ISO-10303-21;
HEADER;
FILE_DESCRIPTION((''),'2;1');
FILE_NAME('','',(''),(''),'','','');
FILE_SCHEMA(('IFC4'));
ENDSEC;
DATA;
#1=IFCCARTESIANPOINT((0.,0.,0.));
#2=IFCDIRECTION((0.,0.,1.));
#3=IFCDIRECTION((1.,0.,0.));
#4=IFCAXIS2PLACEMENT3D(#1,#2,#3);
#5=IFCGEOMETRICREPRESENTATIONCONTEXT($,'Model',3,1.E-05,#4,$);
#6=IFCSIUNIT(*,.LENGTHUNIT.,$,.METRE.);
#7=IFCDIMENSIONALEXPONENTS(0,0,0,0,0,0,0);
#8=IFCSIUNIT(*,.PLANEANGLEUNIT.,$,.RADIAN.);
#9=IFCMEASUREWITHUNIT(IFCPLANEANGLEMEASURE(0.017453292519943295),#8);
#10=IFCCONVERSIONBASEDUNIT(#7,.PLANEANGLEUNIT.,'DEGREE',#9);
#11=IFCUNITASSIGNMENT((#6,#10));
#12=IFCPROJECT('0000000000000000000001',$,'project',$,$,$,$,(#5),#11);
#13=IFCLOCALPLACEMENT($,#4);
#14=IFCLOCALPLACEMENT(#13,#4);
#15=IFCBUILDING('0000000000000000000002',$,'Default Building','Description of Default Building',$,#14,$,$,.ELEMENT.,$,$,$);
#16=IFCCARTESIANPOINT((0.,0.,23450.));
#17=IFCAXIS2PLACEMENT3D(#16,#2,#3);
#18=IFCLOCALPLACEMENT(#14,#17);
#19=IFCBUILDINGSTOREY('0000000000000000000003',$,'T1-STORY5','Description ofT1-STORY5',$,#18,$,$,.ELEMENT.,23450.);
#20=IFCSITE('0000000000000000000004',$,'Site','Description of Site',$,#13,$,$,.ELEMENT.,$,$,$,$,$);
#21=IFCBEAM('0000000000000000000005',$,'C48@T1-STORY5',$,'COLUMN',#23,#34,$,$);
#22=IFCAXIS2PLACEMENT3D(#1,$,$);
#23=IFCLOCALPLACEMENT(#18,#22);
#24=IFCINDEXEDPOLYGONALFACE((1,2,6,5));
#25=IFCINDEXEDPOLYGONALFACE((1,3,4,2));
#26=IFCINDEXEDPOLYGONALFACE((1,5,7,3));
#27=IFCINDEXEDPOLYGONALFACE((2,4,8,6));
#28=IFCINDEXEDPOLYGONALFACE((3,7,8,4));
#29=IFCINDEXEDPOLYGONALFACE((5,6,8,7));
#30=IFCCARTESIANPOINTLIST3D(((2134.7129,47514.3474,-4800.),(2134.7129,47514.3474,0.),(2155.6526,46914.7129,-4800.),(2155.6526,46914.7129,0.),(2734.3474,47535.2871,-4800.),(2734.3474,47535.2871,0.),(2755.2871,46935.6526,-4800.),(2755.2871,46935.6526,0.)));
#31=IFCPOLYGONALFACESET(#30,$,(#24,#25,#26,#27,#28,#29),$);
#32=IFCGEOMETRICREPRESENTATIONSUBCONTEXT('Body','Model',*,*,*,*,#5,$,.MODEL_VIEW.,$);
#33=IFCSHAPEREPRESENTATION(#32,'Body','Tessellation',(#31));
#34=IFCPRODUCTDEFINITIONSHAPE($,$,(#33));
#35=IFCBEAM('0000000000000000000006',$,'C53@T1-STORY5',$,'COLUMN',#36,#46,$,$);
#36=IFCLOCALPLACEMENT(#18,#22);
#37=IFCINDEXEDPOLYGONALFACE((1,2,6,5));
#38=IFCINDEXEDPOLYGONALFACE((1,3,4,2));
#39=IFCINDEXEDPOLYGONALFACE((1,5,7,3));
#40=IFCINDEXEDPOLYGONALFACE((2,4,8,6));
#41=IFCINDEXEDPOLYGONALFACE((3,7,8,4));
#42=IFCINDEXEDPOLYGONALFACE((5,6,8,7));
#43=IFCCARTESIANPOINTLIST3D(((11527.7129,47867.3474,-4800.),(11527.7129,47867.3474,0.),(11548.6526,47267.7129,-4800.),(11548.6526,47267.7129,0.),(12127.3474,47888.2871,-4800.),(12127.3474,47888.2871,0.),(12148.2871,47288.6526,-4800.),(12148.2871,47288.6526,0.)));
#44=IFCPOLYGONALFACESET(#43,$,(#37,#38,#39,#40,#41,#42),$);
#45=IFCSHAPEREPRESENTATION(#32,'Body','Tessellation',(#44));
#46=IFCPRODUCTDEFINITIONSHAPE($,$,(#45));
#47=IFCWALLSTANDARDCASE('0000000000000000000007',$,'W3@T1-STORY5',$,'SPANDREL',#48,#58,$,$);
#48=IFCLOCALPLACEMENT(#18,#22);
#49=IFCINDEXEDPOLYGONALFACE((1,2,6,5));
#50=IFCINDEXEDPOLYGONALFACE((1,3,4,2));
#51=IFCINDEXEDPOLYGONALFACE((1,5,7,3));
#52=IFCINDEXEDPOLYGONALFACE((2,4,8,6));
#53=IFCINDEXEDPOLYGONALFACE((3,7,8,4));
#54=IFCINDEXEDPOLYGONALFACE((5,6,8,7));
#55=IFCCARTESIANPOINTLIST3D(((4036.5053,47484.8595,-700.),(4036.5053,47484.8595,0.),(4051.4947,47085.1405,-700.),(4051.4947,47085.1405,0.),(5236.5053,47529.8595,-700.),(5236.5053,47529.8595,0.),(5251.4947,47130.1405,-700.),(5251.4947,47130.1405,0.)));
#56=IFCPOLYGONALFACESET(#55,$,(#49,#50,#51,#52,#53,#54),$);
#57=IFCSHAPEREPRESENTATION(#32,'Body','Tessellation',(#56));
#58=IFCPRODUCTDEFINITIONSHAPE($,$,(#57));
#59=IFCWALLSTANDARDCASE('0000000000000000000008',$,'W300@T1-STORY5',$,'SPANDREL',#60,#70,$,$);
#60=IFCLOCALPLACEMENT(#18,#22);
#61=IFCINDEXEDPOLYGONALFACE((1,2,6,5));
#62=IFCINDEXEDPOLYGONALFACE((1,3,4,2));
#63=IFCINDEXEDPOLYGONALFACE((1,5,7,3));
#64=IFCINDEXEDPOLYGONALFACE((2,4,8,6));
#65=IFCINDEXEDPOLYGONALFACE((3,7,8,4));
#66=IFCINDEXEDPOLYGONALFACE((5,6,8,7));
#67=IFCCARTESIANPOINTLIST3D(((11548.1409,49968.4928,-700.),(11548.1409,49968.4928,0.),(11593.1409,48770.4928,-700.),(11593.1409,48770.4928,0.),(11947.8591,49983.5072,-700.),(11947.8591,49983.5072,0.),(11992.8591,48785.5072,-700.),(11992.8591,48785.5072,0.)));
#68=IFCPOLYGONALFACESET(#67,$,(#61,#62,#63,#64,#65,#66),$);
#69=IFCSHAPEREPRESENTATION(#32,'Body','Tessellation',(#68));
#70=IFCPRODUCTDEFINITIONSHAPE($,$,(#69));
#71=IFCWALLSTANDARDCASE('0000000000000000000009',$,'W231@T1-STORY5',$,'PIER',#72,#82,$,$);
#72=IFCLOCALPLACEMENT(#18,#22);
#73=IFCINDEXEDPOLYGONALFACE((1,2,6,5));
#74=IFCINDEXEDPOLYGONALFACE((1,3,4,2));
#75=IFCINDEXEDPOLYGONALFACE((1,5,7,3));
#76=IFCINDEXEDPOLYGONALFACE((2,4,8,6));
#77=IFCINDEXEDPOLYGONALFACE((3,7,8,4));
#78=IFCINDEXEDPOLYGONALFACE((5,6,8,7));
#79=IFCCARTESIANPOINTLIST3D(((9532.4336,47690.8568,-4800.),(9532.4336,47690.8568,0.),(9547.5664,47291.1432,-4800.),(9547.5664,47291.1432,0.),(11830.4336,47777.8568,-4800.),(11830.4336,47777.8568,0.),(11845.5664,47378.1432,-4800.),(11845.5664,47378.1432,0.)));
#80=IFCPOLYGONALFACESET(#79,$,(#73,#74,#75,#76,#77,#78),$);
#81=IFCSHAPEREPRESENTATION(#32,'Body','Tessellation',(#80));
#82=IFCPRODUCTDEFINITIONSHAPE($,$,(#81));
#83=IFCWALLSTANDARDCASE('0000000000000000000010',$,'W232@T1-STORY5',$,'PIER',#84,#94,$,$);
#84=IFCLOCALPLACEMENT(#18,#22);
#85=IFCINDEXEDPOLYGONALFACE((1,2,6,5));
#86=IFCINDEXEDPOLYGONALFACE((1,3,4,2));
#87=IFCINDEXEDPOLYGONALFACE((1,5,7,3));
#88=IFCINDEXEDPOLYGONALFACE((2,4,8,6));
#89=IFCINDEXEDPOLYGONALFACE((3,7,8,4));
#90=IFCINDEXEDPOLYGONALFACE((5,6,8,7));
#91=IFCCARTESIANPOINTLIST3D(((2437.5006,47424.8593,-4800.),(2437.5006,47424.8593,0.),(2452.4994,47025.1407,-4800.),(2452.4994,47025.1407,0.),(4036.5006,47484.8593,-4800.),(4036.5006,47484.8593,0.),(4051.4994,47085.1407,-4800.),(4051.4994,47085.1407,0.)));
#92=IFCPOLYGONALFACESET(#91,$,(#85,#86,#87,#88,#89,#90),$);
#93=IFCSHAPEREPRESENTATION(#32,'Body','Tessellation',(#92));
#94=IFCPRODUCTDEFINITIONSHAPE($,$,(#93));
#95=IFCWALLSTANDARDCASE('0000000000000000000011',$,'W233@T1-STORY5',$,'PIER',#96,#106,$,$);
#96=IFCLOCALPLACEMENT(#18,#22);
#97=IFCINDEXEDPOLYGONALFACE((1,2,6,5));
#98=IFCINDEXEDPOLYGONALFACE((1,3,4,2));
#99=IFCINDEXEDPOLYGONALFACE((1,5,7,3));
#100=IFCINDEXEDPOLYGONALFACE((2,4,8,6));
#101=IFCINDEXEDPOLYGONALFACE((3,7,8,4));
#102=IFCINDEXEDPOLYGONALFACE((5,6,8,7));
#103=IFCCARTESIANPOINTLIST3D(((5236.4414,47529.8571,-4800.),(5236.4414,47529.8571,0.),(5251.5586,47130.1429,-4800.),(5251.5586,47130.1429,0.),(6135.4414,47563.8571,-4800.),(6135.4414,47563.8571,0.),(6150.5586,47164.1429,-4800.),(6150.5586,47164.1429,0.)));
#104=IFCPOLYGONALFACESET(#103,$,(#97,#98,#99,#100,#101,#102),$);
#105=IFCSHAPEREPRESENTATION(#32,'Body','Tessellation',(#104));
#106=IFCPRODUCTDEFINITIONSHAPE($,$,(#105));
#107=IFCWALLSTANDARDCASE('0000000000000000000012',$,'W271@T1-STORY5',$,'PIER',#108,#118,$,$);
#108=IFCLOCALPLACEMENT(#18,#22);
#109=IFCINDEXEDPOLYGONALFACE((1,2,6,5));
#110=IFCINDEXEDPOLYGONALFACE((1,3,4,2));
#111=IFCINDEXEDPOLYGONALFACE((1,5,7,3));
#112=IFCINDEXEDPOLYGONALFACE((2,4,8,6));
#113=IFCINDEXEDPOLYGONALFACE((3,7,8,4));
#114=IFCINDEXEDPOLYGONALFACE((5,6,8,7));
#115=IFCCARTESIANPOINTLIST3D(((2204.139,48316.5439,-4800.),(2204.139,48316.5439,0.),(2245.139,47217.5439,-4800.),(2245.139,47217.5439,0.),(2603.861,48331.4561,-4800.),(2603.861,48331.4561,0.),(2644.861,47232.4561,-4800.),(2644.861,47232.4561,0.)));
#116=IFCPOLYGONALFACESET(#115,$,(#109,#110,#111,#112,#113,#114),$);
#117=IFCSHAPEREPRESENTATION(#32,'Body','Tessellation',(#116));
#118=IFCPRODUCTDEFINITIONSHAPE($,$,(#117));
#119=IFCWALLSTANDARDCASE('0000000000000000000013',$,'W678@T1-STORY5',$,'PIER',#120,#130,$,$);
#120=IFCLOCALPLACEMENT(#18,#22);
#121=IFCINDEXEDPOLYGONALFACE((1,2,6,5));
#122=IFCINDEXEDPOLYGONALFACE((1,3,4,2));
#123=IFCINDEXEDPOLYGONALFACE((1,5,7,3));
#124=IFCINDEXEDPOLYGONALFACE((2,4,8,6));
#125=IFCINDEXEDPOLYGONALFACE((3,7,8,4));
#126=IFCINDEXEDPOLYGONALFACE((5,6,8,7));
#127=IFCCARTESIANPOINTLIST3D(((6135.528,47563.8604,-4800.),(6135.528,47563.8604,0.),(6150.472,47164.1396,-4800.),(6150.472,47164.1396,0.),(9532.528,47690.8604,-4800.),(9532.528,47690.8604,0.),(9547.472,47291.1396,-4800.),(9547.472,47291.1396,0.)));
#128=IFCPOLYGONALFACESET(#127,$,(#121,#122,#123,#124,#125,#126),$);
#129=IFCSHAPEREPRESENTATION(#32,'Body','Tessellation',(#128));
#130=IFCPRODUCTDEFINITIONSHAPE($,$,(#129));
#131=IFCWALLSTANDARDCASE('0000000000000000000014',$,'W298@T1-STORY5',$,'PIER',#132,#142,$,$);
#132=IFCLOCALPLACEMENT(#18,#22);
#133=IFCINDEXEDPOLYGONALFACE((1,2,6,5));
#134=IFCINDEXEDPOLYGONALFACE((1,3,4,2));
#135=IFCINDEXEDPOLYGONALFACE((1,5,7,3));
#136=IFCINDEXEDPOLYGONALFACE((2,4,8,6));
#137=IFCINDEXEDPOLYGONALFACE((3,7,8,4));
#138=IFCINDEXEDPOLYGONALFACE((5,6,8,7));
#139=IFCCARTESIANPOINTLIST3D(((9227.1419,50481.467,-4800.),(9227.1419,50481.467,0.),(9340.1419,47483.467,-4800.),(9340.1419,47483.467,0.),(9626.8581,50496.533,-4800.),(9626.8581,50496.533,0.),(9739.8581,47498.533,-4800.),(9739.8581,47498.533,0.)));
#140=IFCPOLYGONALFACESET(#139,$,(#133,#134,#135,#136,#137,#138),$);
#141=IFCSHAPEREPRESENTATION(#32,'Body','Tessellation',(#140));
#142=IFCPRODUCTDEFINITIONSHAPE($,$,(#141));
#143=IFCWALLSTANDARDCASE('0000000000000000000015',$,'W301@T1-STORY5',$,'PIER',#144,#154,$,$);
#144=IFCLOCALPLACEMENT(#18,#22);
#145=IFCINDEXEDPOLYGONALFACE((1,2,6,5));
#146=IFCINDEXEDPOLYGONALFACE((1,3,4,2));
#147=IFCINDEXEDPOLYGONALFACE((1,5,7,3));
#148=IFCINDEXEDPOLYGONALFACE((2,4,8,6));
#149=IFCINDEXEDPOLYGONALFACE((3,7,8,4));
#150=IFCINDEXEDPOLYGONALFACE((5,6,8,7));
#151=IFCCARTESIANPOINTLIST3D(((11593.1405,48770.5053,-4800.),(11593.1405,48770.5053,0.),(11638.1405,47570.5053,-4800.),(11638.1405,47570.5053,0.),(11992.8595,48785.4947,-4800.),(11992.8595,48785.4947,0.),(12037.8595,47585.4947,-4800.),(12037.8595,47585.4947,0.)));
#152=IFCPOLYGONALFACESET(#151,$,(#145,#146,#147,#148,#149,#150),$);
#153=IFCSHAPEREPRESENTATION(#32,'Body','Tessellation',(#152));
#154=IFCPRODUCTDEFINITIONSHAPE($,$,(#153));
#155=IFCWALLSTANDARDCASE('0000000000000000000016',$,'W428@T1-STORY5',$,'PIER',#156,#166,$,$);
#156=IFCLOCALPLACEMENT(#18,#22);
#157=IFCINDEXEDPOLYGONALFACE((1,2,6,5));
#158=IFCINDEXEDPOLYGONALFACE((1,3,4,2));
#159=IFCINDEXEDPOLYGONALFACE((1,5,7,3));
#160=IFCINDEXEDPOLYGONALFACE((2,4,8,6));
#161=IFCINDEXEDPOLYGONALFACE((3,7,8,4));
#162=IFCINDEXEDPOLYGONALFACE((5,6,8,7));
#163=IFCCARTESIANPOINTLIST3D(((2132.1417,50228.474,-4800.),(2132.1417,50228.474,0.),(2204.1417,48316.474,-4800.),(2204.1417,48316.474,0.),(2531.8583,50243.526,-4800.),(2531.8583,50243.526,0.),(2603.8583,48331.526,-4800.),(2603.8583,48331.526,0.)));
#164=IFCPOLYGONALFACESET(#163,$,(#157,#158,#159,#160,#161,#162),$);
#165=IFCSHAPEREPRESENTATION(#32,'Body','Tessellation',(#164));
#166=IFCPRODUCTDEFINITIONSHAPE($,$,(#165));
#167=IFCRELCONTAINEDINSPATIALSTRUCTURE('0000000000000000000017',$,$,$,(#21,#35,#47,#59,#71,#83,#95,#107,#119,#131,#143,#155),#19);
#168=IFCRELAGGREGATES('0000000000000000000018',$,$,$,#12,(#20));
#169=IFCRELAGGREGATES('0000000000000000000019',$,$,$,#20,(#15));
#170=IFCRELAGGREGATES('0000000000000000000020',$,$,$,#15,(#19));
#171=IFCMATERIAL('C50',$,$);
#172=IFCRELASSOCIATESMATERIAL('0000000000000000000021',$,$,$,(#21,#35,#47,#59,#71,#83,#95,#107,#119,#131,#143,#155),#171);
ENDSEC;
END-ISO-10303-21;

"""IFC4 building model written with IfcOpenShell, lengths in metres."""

from ifc_helpers import new_model, entity, si_unit, converted_unit, frame, origin_with_axes, place, context, subcontext, project, spatial, indexed_curve, rectangle, outline, extrude, material, element, save


model = new_model("IFC4")

# Units and contexts
model_context = context("Model", 3, precision=1e-05, world=origin_with_axes())
body_context = subcontext(model_context, "Body", "Model", "MODEL_VIEW")
ifc_project = project(units=[si_unit("LENGTHUNIT", "METRE"), converted_unit("PLANEANGLEUNIT", "DEGREE", entity("IfcPlaneAngleMeasure", 0.017453292519943295), si_unit("PLANEANGLEUNIT", "RADIAN"), dimensions=[0, 0, 0, 0, 0, 0, 0])], contexts=[model_context])

# Site, building, storey
site_placement = place(None, origin_with_axes())
site = spatial("IfcSite", under=ifc_project, at=site_placement, Name="Site", Description="Description of Site", CompositionType="ELEMENT")
building_placement = place(site_placement, origin_with_axes())
building = spatial("IfcBuilding", under=site, at=building_placement, Name="Default Building", Description="Description of Default Building", CompositionType="ELEMENT")
storey_placement = place(building_placement, frame((0.0, 0.0, 23450.0), z_axis=(0.0, 0.0, 1.0), x_axis=(1.0, 0.0, 0.0)))
storey = spatial("IfcBuildingStorey", under=building, at=storey_placement, Name="T1-STORY5", Description="Description ofT1-STORY5", CompositionType="ELEMENT", Elevation=23450.0)

# Beams
ifc_material_1 = material(Name="C50")
for number, where, z_axis, x_axis, name in (
    (1, (2445.0, 47225.0, -4800.0), (0.0, 0.0, 1.0), (-0.999391, -0.034899, 0.0), "C48@T1-STORY5"),
    (2, (11838.0, 47578.0, -4800.0), (0.0, 0.0, 1.0), (-0.999391, -0.034899, 0.0), "C53@T1-STORY5"),
):
    element("IfcBeam", number, at=place(storey_placement, frame(where, z_axis=z_axis, x_axis=x_axis)), inside=storey, material=ifc_material_1, Name=name, ObjectType="COLUMN", context=body_context, shape_type="SweptSolid", body=[
        extrude(rectangle(XDim=600.0, YDim=600.0), origin_with_axes(), (0.0, 0.0, 1.0), 4800.0),
    ])

# Walls
wall_1_placement = place(storey_placement, frame((4044.0, 47285.0, -700.0), z_axis=(0.0, 0.0, 1.0), x_axis=(0.999298, 0.037474, 0.0)))
element("IfcWallStandardCase", 3, at=wall_1_placement, inside=storey, material=ifc_material_1, Name="W3@T1-STORY5", ObjectType="SPANDREL", context=body_context, shape_type="SweptSolid", body=[
    extrude(outline(indexed_curve([(0.0, -200.0), (0.0, 200.0), (1200.8435, 200.0), (1200.8435, -200.0), (0.0, -200.0)], self_intersect=False)), origin_with_axes(), (0.0, 0.0, 1.0), 700.0),
])
wall_2_placement = place(storey_placement, frame((11748.0, 49976.0, -700.0), z_axis=(0.0, 0.0, 1.0), x_axis=(0.037536, -0.999295, 0.0)))
element("IfcWallStandardCase", 4, at=wall_2_placement, inside=storey, material=ifc_material_1, Name="W300@T1-STORY5", ObjectType="SPANDREL", context=body_context, shape_type="SweptSolid", body=[
    extrude(outline(indexed_curve([(0.0, -200.0), (0.0, 200.0), (1198.8449, 200.0), (1198.8449, -200.0), (0.0, -200.0)], self_intersect=False)), origin_with_axes(), (0.0, 0.0, 1.0), 700.0),
])
wall_3_placement = place(storey_placement, frame((9540.0, 47491.0, -4800.0), z_axis=(0.0, 0.0, 1.0), x_axis=(0.999284, 0.037832, 0.0)))
element("IfcWallStandardCase", 5, at=wall_3_placement, inside=storey, material=ifc_material_1, Name="W231@T1-STORY5", ObjectType="PIER", context=body_context, shape_type="SweptSolid", body=[
    extrude(outline(indexed_curve([(0.0, -200.0), (0.0, 200.0), (2299.6463, 200.0), (2299.6463, -200.0), (0.0, -200.0)], self_intersect=False)), origin_with_axes(), (0.0, 0.0, 1.0), 4800.0),
])
wall_4_placement = place(storey_placement, frame((2445.0, 47225.0, -4800.0), z_axis=(0.0, 0.0, 1.0), x_axis=(0.999297, 0.037497, 0.0)))
element("IfcWallStandardCase", 6, at=wall_4_placement, inside=storey, material=ifc_material_1, Name="W232@T1-STORY5", ObjectType="PIER", context=body_context, shape_type="SweptSolid", body=[
    extrude(outline(indexed_curve([(0.0, -200.0), (0.0, 200.0), (1600.1253, 200.0), (1600.1253, -200.0), (0.0, -200.0)], self_intersect=False)), origin_with_axes(), (0.0, 0.0, 1.0), 4800.0),
])
wall_5_placement = place(storey_placement, frame((5244.0, 47330.0, -4800.0), z_axis=(0.0, 0.0, 1.0), x_axis=(0.999286, 0.037793, 0.0)))
element("IfcWallStandardCase", 7, at=wall_5_placement, inside=storey, material=ifc_material_1, Name="W233@T1-STORY5", ObjectType="PIER", context=body_context, shape_type="SweptSolid", body=[
    extrude(outline(indexed_curve([(0.0, -200.0), (0.0, 200.0), (899.6427, 200.0), (899.6427, -200.0), (0.0, -200.0)], self_intersect=False)), origin_with_axes(), (0.0, 0.0, 1.0), 4800.0),
])
wall_6_placement = place(storey_placement, frame((2404.0, 48324.0, -4800.0), z_axis=(0.0, 0.0, 1.0), x_axis=(0.037281, -0.999305, 0.0)))
element("IfcWallStandardCase", 8, at=wall_6_placement, inside=storey, material=ifc_material_1, Name="W271@T1-STORY5", ObjectType="PIER", context=body_context, shape_type="SweptSolid", body=[
    extrude(outline(indexed_curve([(0.0, -200.0), (0.0, 200.0), (1099.7645, 200.0), (1099.7645, -200.0), (0.0, -200.0)], self_intersect=False)), origin_with_axes(), (0.0, 0.0, 1.0), 4800.0),
])
wall_7_placement = place(storey_placement, frame((6143.0, 47364.0, -4800.0), z_axis=(0.0, 0.0, 1.0), x_axis=(0.999302, 0.03736, 0.0)))
element("IfcWallStandardCase", 9, at=wall_7_placement, inside=storey, material=ifc_material_1, Name="W678@T1-STORY5", ObjectType="PIER", context=body_context, shape_type="SweptSolid", body=[
    extrude(outline(indexed_curve([(0.0, -200.0), (0.0, 200.0), (3399.3732, 200.0), (3399.3732, -200.0), (0.0, -200.0)], self_intersect=False)), origin_with_axes(), (0.0, 0.0, 1.0), 4800.0),
])
wall_8_placement = place(storey_placement, frame((9427.0, 50489.0, -4800.0), z_axis=(0.0, 0.0, 1.0), x_axis=(0.037665, -0.99929, 0.0)))
element("IfcWallStandardCase", 10, at=wall_8_placement, inside=storey, material=ifc_material_1, Name="W298@T1-STORY5", ObjectType="PIER", context=body_context, shape_type="SweptSolid", body=[
    extrude(outline(indexed_curve([(0.0, -200.0), (0.0, 200.0), (3000.1288, 200.0), (3000.1288, -200.0), (0.0, -200.0)], self_intersect=False)), origin_with_axes(), (0.0, 0.0, 1.0), 4800.0),
])
wall_9_placement = place(storey_placement, frame((11793.0, 48778.0, -4800.0), z_axis=(0.0, 0.0, 1.0), x_axis=(0.037474, -0.999298, 0.0)))
element("IfcWallStandardCase", 11, at=wall_9_placement, inside=storey, material=ifc_material_1, Name="W301@T1-STORY5", ObjectType="PIER", context=body_context, shape_type="SweptSolid", body=[
    extrude(outline(indexed_curve([(0.0, -200.0), (0.0, 200.0), (1200.8435, 200.0), (1200.8435, -200.0), (0.0, -200.0)], self_intersect=False)), origin_with_axes(), (0.0, 0.0, 1.0), 4800.0),
])
wall_10_placement = place(storey_placement, frame((2332.0, 50236.0, -4800.0), z_axis=(0.0, 0.0, 1.0), x_axis=(0.03763, -0.999292, 0.0)))
element("IfcWallStandardCase", 12, at=wall_10_placement, inside=storey, material=ifc_material_1, Name="W428@T1-STORY5", ObjectType="PIER", context=body_context, shape_type="SweptSolid", body=[
    extrude(outline(indexed_curve([(0.0, -200.0), (0.0, 200.0), (1913.3552, 200.0), (1913.3552, -200.0), (0.0, -200.0)], self_intersect=False)), origin_with_axes(), (0.0, 0.0, 1.0), 4800.0),
])

save(model, "model.ifc")
